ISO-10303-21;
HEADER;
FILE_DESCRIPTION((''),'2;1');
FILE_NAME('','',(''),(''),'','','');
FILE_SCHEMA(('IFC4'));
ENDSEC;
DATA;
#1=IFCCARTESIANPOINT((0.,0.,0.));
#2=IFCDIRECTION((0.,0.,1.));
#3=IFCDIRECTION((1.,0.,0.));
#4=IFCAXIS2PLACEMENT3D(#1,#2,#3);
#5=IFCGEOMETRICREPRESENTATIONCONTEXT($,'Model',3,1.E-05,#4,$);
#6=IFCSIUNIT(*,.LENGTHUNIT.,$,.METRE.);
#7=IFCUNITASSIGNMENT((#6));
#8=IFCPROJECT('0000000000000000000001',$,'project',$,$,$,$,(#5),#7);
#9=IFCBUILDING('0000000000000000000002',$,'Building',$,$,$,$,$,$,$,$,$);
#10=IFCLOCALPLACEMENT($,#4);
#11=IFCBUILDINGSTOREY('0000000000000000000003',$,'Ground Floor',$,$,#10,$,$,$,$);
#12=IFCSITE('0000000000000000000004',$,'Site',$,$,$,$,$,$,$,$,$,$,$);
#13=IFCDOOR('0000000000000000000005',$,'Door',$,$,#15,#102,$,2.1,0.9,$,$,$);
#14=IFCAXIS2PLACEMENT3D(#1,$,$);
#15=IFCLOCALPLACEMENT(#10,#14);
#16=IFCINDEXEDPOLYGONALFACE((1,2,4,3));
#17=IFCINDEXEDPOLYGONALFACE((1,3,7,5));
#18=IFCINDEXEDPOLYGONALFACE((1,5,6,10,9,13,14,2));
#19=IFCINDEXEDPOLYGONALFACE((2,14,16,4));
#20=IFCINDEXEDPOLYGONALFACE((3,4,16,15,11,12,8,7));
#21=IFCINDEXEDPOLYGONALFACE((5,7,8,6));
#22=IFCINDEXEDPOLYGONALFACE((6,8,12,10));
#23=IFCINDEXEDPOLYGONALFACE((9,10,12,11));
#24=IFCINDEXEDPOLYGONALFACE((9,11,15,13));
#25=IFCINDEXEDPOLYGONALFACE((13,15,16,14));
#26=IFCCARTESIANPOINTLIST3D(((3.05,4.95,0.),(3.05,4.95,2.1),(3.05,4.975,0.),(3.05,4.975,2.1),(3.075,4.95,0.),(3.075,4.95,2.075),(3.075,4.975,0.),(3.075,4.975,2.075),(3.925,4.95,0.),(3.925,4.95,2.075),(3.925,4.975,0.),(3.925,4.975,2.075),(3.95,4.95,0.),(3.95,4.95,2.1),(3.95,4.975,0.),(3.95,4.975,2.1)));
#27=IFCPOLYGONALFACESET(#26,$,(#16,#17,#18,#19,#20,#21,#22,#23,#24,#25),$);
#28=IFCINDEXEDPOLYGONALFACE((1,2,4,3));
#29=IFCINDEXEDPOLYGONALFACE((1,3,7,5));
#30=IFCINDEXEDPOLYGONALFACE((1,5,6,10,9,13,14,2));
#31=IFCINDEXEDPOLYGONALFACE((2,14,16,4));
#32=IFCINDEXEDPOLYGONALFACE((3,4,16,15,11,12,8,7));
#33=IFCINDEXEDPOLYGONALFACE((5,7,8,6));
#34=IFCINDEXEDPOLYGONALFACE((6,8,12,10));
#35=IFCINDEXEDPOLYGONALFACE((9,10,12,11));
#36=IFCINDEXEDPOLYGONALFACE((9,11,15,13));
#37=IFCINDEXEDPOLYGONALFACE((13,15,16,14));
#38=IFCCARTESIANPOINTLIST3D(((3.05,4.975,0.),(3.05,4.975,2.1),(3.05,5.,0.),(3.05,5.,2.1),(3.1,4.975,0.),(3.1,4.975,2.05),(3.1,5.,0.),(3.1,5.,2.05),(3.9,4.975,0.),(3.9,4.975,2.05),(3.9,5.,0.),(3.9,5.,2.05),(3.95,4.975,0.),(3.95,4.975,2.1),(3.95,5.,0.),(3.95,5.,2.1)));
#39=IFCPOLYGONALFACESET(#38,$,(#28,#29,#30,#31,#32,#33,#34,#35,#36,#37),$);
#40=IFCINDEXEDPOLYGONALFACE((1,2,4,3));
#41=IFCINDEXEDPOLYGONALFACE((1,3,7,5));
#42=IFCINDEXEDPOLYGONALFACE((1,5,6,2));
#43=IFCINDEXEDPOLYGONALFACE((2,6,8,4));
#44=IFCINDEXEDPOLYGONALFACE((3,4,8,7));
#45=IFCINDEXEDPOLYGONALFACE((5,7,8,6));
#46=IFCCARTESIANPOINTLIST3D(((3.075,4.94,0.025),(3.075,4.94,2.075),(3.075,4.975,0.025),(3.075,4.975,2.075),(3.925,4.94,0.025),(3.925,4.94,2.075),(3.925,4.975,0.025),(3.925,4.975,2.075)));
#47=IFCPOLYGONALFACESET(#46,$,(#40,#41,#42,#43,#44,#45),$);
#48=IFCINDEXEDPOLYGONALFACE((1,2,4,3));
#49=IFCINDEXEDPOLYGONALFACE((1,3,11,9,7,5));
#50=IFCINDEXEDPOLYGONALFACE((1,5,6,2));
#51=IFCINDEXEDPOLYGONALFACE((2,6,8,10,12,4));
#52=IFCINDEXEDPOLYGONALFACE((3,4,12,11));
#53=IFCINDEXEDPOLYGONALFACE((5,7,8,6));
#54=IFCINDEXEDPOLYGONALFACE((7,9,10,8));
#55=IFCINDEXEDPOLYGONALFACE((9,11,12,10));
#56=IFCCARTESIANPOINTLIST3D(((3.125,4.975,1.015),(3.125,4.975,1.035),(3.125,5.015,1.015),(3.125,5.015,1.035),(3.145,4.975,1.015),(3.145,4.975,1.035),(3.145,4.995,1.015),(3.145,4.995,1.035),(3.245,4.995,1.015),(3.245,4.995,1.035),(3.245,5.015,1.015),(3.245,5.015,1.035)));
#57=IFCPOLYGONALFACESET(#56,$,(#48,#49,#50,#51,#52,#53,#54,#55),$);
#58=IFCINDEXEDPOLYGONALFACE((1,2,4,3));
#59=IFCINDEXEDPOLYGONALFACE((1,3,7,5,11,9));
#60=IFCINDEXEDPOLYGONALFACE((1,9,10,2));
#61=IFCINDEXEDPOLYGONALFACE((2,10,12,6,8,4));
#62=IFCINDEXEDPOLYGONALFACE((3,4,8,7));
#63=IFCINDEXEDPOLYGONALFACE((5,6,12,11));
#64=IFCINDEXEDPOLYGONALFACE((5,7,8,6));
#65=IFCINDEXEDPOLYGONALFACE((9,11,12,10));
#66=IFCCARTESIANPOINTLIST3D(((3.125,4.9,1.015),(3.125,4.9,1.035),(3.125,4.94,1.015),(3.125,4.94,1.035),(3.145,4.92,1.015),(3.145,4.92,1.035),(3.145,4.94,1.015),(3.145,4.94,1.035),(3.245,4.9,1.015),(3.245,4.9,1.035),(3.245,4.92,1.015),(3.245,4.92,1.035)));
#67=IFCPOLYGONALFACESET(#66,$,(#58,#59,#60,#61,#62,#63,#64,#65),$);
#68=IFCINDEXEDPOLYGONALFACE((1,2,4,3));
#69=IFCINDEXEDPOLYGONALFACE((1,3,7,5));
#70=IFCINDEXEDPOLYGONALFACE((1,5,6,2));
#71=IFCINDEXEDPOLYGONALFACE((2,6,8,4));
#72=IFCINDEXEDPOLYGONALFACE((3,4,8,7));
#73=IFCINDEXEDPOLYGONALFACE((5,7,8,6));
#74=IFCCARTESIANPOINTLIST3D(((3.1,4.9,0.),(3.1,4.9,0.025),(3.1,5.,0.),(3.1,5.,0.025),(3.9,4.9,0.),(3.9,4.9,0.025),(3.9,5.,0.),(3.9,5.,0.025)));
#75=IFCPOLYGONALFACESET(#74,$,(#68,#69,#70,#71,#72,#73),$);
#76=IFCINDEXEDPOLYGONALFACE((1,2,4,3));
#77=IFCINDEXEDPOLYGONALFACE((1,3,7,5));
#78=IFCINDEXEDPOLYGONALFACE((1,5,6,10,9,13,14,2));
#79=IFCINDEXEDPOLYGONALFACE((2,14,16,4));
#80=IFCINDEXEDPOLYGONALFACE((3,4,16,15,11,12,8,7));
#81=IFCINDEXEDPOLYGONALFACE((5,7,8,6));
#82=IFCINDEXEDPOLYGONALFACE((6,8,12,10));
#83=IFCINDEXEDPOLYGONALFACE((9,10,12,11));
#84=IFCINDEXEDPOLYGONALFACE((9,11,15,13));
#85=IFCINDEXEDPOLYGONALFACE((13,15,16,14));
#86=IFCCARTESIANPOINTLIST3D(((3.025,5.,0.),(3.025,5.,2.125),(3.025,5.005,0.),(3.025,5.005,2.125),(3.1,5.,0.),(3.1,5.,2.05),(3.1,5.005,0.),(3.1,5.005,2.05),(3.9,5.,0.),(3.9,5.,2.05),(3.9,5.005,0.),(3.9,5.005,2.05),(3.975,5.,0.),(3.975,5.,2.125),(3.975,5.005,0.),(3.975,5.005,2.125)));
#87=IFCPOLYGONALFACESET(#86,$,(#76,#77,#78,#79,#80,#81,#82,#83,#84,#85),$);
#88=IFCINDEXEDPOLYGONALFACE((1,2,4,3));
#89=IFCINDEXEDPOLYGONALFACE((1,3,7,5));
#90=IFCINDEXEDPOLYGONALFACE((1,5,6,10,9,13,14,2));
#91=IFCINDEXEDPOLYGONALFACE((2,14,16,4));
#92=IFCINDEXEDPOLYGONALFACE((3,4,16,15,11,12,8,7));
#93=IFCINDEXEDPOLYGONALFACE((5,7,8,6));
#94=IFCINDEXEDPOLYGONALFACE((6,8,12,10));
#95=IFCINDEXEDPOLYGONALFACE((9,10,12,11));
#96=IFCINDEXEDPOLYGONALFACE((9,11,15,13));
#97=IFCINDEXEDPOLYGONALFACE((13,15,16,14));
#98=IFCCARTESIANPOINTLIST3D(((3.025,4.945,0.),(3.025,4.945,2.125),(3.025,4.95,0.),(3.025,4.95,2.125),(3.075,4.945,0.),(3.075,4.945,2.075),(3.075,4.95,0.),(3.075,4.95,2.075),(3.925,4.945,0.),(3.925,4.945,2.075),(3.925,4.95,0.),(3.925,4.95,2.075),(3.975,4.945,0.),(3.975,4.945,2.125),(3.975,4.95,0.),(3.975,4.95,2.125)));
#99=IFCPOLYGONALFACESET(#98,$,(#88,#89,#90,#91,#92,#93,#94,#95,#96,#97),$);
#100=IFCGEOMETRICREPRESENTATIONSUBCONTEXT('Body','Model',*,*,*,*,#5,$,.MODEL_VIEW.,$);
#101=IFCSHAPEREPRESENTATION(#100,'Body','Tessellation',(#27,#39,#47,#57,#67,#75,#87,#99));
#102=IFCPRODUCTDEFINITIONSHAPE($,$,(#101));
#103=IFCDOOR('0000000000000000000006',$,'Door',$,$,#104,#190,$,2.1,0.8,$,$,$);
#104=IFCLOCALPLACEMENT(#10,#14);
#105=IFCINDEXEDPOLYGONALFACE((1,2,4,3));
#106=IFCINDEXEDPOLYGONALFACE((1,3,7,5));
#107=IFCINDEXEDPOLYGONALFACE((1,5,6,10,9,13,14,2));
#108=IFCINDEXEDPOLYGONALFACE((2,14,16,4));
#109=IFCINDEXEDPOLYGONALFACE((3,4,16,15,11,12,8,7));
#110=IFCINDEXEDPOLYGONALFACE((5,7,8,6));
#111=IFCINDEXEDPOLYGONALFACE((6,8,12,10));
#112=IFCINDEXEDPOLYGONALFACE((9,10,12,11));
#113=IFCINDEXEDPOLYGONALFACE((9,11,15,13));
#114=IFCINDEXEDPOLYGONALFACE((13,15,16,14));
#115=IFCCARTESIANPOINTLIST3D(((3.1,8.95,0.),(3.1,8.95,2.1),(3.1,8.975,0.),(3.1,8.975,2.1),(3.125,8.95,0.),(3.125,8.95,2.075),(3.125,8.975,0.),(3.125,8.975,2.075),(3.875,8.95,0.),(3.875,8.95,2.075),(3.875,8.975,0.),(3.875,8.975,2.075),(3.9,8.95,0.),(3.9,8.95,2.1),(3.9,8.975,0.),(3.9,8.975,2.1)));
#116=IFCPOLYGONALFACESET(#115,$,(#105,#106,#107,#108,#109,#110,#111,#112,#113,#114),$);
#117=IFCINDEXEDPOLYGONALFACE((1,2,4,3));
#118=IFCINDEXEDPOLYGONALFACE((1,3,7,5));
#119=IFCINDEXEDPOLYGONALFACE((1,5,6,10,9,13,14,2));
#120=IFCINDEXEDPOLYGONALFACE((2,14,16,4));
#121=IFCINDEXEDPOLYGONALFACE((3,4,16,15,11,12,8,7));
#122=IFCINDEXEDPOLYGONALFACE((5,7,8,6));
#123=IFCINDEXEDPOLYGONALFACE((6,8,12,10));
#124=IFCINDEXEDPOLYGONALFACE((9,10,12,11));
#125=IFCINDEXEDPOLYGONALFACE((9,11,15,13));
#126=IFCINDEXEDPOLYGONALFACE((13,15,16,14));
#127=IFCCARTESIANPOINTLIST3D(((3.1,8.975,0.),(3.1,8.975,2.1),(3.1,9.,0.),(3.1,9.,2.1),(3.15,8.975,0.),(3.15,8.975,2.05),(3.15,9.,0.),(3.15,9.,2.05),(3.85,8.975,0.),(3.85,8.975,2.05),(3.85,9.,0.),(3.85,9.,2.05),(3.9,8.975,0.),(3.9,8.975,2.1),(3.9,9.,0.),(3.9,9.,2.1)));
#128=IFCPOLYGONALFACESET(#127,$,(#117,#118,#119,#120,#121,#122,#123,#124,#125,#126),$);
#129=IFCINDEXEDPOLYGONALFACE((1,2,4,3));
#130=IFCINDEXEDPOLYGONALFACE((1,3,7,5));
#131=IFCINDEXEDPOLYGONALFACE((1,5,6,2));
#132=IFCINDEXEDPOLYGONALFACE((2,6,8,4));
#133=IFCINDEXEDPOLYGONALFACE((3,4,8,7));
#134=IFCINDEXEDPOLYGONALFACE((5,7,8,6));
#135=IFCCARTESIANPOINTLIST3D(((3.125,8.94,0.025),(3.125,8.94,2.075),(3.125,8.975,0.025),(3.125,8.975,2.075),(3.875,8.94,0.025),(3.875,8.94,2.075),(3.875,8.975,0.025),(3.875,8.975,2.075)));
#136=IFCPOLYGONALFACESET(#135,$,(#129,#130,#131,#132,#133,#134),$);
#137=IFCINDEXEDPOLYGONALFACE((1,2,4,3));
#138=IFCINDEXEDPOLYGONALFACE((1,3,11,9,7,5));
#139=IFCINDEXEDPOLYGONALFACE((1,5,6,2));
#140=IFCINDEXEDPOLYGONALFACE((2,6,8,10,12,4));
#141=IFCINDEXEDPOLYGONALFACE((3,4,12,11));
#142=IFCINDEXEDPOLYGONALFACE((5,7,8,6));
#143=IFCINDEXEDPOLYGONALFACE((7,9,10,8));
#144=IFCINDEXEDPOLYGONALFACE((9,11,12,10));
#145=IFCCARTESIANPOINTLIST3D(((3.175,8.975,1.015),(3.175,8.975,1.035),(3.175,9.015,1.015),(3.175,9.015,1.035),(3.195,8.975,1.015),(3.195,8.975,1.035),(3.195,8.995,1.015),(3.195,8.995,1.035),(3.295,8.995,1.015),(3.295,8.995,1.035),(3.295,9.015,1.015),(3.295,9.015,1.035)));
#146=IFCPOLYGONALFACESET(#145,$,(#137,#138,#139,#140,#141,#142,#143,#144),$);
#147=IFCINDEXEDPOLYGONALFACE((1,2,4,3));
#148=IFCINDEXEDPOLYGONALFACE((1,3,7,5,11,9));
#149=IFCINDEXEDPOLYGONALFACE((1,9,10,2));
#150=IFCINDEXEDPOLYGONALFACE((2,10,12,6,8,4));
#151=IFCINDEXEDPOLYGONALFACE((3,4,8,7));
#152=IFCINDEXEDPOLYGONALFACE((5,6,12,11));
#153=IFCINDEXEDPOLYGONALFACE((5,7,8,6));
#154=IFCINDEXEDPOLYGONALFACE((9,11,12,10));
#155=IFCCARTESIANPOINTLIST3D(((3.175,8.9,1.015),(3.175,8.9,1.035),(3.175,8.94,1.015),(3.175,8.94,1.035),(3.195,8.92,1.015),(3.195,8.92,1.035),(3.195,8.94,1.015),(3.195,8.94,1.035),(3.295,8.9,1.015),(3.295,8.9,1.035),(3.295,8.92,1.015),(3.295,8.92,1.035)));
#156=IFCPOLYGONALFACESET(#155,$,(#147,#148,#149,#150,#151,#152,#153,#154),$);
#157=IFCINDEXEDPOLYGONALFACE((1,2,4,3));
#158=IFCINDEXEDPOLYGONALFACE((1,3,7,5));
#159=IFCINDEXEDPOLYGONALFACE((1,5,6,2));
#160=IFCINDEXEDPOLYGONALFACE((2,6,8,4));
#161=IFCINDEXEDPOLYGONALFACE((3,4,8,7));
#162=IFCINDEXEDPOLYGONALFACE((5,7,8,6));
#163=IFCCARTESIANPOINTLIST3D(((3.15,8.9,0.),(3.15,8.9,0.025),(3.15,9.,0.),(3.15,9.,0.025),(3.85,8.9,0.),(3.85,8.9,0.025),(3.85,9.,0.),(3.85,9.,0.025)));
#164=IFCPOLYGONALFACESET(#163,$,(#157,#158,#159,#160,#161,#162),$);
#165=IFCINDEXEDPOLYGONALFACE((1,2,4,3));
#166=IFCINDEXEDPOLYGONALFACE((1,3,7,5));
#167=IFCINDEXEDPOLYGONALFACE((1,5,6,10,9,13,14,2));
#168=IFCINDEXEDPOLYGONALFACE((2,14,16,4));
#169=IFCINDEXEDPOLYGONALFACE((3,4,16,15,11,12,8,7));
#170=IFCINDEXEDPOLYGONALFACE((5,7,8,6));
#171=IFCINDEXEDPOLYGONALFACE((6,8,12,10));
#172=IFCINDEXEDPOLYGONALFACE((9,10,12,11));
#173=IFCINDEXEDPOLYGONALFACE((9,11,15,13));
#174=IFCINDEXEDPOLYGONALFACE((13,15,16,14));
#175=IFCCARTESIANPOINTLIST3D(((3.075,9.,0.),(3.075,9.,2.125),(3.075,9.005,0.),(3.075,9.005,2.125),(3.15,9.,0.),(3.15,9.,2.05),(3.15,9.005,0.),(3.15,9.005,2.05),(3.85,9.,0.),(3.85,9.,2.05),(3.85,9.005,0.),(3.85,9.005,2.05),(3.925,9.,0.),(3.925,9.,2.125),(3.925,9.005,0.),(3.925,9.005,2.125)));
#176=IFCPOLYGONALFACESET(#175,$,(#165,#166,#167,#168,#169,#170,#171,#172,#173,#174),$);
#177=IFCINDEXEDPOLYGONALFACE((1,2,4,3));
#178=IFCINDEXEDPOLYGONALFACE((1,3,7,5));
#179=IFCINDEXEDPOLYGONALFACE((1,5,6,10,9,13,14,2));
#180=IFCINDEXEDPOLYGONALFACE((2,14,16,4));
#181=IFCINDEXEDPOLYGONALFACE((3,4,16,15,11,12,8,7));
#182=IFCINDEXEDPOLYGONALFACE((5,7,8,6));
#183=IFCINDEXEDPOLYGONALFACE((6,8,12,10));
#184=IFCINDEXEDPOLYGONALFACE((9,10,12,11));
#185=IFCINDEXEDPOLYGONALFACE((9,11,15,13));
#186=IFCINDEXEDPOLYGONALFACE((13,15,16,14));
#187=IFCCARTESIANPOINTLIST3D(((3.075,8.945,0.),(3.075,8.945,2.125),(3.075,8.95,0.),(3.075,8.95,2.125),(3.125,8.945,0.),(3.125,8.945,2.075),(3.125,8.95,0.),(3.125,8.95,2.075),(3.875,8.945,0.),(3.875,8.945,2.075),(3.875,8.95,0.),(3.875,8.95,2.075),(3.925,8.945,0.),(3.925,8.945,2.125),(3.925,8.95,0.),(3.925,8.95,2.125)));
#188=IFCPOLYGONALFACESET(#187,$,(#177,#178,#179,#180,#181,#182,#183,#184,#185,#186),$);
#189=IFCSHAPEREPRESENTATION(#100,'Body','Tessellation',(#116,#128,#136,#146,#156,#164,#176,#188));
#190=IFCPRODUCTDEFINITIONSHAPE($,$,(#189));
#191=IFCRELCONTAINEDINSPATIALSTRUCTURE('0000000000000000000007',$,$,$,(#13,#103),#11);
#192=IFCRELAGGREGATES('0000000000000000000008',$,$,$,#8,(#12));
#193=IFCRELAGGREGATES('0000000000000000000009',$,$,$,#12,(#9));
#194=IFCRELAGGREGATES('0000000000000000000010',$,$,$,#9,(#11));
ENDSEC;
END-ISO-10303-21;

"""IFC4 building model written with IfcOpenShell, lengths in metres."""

from ifc_helpers import new_model, si_unit, frame, origin_with_axes, place, context, subcontext, project, spatial, line, indexed_curve, outline, extrude, element, save


model = new_model("IFC4")

# Units and contexts
model_context = context("Model", 3, precision=1e-05, world=origin_with_axes())
body_context = subcontext(model_context, "Body", "Model", "MODEL_VIEW")
ifc_project = project(units=[si_unit("LENGTHUNIT", "METRE")], contexts=[model_context])

# Site, building, storey
site = spatial("IfcSite", under=ifc_project, Name="Site")
building = spatial("IfcBuilding", under=site, Name="Building")
storey_placement = place(None, origin_with_axes())
storey = spatial("IfcBuildingStorey", under=building, at=storey_placement, Name="Ground Floor")

# Doors
door_1_placement = place(storey_placement, frame((3.95, 5.0, 0.0), z_axis=(0.0, 0.0, 1.0), x_axis=(-1.0, 0.0, 0.0)))
element("IfcDoor", 1, at=door_1_placement, inside=storey, Name="Door", OverallHeight=2.1, OverallWidth=0.9, context=body_context, shape_type="SweptSolid", body=[
    extrude(outline(indexed_curve([(0.0, 0.0), (0.0, 2.1), (0.9, 2.1), (0.9, 0.0), (0.875, 0.0), (0.875, 2.075), (0.025, 2.075), (0.025, 0.0)], segments=[line(1, 2, 3, 4, 5, 6, 7, 8, 1)])), frame((0.0, 0.025, 0.0), z_axis=(0.0, -1.0, 0.0), x_axis=(1.0, 0.0, 0.0)), (0.0, 0.0, -1.0), 0.025),
    extrude(outline(indexed_curve([(0.0, 0.0), (0.0, 2.1), (0.9, 2.1), (0.9, 0.0), (0.85, 0.0), (0.85, 2.05), (0.05, 2.05), (0.05, 0.0)], segments=[line(1, 2, 3, 4, 5, 6, 7, 8, 1)])), frame((0.0, 0.0, 0.0), z_axis=(0.0, -1.0, 0.0), x_axis=(1.0, 0.0, 0.0)), (0.0, 0.0, -1.0), 0.025),
    extrude(outline(indexed_curve([(0.0, 0.0), (0.85, 0.0), (0.85, 0.035), (0.0, 0.035)], segments=[line(1, 2, 3, 4, 1)])), frame((0.025, 0.025, 0.025), z_axis=(0.0, 0.0, 1.0), x_axis=(1.0, 0.0, 0.0)), (0.0, 0.0, 1.0), 2.05),
    extrude(outline(indexed_curve([(0.0, 0.0), (0.0, -0.04), (-0.12, -0.04), (-0.12, -0.02), (-0.02, -0.02), (-0.02, 0.0)], segments=[line(1, 2, 3, 4, 5, 6, 1)])), frame((0.825, 0.025, 1.015), z_axis=(0.0, 0.0, 1.0), x_axis=(1.0, 0.0, 0.0)), (0.0, 0.0, 1.0), 0.02),
    extrude(outline(indexed_curve([(0.0, 0.0), (0.0, 0.04), (-0.12, 0.04), (-0.12, 0.02), (-0.02, 0.02), (-0.02, 0.0)], segments=[line(1, 2, 3, 4, 5, 6, 1)])), frame((0.825, 0.06, 1.015), z_axis=(0.0, 0.0, 1.0), x_axis=(1.0, 0.0, 0.0)), (0.0, 0.0, 1.0), 0.02),
    extrude(outline(indexed_curve([(0.0, 0.0), (0.8, 0.0), (0.8, 0.1), (0.0, 0.1)], segments=[line(1, 2, 3, 4, 1)])), frame((0.05, 0.0, 0.0), z_axis=(0.0, 0.0, 1.0), x_axis=(1.0, 0.0, 0.0)), (0.0, 0.0, 1.0), 0.025),
    extrude(outline(indexed_curve([(0.0, 0.0), (0.0, 2.125), (0.95, 2.125), (0.95, 0.0), (0.875, 0.0), (0.875, 2.05), (0.075, 2.05), (0.075, 0.0)], segments=[line(1, 2, 3, 4, 5, 6, 7, 8, 1)])), frame((-0.025, -0.005, 0.0), z_axis=(0.0, -1.0, 0.0), x_axis=(1.0, 0.0, 0.0)), (0.0, 0.0, -1.0), 0.005),
    extrude(outline(indexed_curve([(0.0, 0.0), (0.0, 2.125), (0.95, 2.125), (0.95, 0.0), (0.9, 0.0), (0.9, 2.075), (0.05, 2.075), (0.05, 0.0)], segments=[line(1, 2, 3, 4, 5, 6, 7, 8, 1)])), frame((-0.025, 0.05, 0.0), z_axis=(0.0, -1.0, 0.0), x_axis=(1.0, 0.0, 0.0)), (0.0, 0.0, -1.0), 0.005),
])
door_2_placement = place(storey_placement, frame((3.9, 9.0, 0.0), z_axis=(0.0, 0.0, 1.0), x_axis=(-1.0, 0.0, 0.0)))
element("IfcDoor", 2, at=door_2_placement, inside=storey, Name="Door", OverallHeight=2.1, OverallWidth=0.8, context=body_context, shape_type="SweptSolid", body=[
    extrude(outline(indexed_curve([(0.0, 0.0), (0.0, 2.1), (0.8, 2.1), (0.8, 0.0), (0.775, 0.0), (0.775, 2.075), (0.025, 2.075), (0.025, 0.0)], segments=[line(1, 2, 3, 4, 5, 6, 7, 8, 1)])), frame((0.0, 0.025, 0.0), z_axis=(0.0, -1.0, 0.0), x_axis=(1.0, 0.0, 0.0)), (0.0, 0.0, -1.0), 0.025),
    extrude(outline(indexed_curve([(0.0, 0.0), (0.0, 2.1), (0.8, 2.1), (0.8, 0.0), (0.75, 0.0), (0.75, 2.05), (0.05, 2.05), (0.05, 0.0)], segments=[line(1, 2, 3, 4, 5, 6, 7, 8, 1)])), frame((0.0, 0.0, 0.0), z_axis=(0.0, -1.0, 0.0), x_axis=(1.0, 0.0, 0.0)), (0.0, 0.0, -1.0), 0.025),
    extrude(outline(indexed_curve([(0.0, 0.0), (0.75, 0.0), (0.75, 0.035), (0.0, 0.035)], segments=[line(1, 2, 3, 4, 1)])), frame((0.025, 0.025, 0.025), z_axis=(0.0, 0.0, 1.0), x_axis=(1.0, 0.0, 0.0)), (0.0, 0.0, 1.0), 2.05),
    extrude(outline(indexed_curve([(0.0, 0.0), (0.0, -0.04), (-0.12, -0.04), (-0.12, -0.02), (-0.02, -0.02), (-0.02, 0.0)], segments=[line(1, 2, 3, 4, 5, 6, 1)])), frame((0.725, 0.025, 1.015), z_axis=(0.0, 0.0, 1.0), x_axis=(1.0, 0.0, 0.0)), (0.0, 0.0, 1.0), 0.02),
    extrude(outline(indexed_curve([(0.0, 0.0), (0.0, 0.04), (-0.12, 0.04), (-0.12, 0.02), (-0.02, 0.02), (-0.02, 0.0)], segments=[line(1, 2, 3, 4, 5, 6, 1)])), frame((0.725, 0.06, 1.015), z_axis=(0.0, 0.0, 1.0), x_axis=(1.0, 0.0, 0.0)), (0.0, 0.0, 1.0), 0.02),
    extrude(outline(indexed_curve([(0.0, 0.0), (0.7, 0.0), (0.7, 0.1), (0.0, 0.1)], segments=[line(1, 2, 3, 4, 1)])), frame((0.05, 0.0, 0.0), z_axis=(0.0, 0.0, 1.0), x_axis=(1.0, 0.0, 0.0)), (0.0, 0.0, 1.0), 0.025),
    extrude(outline(indexed_curve([(0.0, 0.0), (0.0, 2.125), (0.85, 2.125), (0.85, 0.0), (0.775, 0.0), (0.775, 2.05), (0.075, 2.05), (0.075, 0.0)], segments=[line(1, 2, 3, 4, 5, 6, 7, 8, 1)])), frame((-0.025, -0.005, 0.0), z_axis=(0.0, -1.0, 0.0), x_axis=(1.0, 0.0, 0.0)), (0.0, 0.0, -1.0), 0.005),
    extrude(outline(indexed_curve([(0.0, 0.0), (0.0, 2.125), (0.85, 2.125), (0.85, 0.0), (0.8, 0.0), (0.8, 2.075), (0.05, 2.075), (0.05, 0.0)], segments=[line(1, 2, 3, 4, 5, 6, 7, 8, 1)])), frame((-0.025, 0.05, 0.0), z_axis=(0.0, -1.0, 0.0), x_axis=(1.0, 0.0, 0.0)), (0.0, 0.0, -1.0), 0.005),
])

save(model, "model.ifc")
